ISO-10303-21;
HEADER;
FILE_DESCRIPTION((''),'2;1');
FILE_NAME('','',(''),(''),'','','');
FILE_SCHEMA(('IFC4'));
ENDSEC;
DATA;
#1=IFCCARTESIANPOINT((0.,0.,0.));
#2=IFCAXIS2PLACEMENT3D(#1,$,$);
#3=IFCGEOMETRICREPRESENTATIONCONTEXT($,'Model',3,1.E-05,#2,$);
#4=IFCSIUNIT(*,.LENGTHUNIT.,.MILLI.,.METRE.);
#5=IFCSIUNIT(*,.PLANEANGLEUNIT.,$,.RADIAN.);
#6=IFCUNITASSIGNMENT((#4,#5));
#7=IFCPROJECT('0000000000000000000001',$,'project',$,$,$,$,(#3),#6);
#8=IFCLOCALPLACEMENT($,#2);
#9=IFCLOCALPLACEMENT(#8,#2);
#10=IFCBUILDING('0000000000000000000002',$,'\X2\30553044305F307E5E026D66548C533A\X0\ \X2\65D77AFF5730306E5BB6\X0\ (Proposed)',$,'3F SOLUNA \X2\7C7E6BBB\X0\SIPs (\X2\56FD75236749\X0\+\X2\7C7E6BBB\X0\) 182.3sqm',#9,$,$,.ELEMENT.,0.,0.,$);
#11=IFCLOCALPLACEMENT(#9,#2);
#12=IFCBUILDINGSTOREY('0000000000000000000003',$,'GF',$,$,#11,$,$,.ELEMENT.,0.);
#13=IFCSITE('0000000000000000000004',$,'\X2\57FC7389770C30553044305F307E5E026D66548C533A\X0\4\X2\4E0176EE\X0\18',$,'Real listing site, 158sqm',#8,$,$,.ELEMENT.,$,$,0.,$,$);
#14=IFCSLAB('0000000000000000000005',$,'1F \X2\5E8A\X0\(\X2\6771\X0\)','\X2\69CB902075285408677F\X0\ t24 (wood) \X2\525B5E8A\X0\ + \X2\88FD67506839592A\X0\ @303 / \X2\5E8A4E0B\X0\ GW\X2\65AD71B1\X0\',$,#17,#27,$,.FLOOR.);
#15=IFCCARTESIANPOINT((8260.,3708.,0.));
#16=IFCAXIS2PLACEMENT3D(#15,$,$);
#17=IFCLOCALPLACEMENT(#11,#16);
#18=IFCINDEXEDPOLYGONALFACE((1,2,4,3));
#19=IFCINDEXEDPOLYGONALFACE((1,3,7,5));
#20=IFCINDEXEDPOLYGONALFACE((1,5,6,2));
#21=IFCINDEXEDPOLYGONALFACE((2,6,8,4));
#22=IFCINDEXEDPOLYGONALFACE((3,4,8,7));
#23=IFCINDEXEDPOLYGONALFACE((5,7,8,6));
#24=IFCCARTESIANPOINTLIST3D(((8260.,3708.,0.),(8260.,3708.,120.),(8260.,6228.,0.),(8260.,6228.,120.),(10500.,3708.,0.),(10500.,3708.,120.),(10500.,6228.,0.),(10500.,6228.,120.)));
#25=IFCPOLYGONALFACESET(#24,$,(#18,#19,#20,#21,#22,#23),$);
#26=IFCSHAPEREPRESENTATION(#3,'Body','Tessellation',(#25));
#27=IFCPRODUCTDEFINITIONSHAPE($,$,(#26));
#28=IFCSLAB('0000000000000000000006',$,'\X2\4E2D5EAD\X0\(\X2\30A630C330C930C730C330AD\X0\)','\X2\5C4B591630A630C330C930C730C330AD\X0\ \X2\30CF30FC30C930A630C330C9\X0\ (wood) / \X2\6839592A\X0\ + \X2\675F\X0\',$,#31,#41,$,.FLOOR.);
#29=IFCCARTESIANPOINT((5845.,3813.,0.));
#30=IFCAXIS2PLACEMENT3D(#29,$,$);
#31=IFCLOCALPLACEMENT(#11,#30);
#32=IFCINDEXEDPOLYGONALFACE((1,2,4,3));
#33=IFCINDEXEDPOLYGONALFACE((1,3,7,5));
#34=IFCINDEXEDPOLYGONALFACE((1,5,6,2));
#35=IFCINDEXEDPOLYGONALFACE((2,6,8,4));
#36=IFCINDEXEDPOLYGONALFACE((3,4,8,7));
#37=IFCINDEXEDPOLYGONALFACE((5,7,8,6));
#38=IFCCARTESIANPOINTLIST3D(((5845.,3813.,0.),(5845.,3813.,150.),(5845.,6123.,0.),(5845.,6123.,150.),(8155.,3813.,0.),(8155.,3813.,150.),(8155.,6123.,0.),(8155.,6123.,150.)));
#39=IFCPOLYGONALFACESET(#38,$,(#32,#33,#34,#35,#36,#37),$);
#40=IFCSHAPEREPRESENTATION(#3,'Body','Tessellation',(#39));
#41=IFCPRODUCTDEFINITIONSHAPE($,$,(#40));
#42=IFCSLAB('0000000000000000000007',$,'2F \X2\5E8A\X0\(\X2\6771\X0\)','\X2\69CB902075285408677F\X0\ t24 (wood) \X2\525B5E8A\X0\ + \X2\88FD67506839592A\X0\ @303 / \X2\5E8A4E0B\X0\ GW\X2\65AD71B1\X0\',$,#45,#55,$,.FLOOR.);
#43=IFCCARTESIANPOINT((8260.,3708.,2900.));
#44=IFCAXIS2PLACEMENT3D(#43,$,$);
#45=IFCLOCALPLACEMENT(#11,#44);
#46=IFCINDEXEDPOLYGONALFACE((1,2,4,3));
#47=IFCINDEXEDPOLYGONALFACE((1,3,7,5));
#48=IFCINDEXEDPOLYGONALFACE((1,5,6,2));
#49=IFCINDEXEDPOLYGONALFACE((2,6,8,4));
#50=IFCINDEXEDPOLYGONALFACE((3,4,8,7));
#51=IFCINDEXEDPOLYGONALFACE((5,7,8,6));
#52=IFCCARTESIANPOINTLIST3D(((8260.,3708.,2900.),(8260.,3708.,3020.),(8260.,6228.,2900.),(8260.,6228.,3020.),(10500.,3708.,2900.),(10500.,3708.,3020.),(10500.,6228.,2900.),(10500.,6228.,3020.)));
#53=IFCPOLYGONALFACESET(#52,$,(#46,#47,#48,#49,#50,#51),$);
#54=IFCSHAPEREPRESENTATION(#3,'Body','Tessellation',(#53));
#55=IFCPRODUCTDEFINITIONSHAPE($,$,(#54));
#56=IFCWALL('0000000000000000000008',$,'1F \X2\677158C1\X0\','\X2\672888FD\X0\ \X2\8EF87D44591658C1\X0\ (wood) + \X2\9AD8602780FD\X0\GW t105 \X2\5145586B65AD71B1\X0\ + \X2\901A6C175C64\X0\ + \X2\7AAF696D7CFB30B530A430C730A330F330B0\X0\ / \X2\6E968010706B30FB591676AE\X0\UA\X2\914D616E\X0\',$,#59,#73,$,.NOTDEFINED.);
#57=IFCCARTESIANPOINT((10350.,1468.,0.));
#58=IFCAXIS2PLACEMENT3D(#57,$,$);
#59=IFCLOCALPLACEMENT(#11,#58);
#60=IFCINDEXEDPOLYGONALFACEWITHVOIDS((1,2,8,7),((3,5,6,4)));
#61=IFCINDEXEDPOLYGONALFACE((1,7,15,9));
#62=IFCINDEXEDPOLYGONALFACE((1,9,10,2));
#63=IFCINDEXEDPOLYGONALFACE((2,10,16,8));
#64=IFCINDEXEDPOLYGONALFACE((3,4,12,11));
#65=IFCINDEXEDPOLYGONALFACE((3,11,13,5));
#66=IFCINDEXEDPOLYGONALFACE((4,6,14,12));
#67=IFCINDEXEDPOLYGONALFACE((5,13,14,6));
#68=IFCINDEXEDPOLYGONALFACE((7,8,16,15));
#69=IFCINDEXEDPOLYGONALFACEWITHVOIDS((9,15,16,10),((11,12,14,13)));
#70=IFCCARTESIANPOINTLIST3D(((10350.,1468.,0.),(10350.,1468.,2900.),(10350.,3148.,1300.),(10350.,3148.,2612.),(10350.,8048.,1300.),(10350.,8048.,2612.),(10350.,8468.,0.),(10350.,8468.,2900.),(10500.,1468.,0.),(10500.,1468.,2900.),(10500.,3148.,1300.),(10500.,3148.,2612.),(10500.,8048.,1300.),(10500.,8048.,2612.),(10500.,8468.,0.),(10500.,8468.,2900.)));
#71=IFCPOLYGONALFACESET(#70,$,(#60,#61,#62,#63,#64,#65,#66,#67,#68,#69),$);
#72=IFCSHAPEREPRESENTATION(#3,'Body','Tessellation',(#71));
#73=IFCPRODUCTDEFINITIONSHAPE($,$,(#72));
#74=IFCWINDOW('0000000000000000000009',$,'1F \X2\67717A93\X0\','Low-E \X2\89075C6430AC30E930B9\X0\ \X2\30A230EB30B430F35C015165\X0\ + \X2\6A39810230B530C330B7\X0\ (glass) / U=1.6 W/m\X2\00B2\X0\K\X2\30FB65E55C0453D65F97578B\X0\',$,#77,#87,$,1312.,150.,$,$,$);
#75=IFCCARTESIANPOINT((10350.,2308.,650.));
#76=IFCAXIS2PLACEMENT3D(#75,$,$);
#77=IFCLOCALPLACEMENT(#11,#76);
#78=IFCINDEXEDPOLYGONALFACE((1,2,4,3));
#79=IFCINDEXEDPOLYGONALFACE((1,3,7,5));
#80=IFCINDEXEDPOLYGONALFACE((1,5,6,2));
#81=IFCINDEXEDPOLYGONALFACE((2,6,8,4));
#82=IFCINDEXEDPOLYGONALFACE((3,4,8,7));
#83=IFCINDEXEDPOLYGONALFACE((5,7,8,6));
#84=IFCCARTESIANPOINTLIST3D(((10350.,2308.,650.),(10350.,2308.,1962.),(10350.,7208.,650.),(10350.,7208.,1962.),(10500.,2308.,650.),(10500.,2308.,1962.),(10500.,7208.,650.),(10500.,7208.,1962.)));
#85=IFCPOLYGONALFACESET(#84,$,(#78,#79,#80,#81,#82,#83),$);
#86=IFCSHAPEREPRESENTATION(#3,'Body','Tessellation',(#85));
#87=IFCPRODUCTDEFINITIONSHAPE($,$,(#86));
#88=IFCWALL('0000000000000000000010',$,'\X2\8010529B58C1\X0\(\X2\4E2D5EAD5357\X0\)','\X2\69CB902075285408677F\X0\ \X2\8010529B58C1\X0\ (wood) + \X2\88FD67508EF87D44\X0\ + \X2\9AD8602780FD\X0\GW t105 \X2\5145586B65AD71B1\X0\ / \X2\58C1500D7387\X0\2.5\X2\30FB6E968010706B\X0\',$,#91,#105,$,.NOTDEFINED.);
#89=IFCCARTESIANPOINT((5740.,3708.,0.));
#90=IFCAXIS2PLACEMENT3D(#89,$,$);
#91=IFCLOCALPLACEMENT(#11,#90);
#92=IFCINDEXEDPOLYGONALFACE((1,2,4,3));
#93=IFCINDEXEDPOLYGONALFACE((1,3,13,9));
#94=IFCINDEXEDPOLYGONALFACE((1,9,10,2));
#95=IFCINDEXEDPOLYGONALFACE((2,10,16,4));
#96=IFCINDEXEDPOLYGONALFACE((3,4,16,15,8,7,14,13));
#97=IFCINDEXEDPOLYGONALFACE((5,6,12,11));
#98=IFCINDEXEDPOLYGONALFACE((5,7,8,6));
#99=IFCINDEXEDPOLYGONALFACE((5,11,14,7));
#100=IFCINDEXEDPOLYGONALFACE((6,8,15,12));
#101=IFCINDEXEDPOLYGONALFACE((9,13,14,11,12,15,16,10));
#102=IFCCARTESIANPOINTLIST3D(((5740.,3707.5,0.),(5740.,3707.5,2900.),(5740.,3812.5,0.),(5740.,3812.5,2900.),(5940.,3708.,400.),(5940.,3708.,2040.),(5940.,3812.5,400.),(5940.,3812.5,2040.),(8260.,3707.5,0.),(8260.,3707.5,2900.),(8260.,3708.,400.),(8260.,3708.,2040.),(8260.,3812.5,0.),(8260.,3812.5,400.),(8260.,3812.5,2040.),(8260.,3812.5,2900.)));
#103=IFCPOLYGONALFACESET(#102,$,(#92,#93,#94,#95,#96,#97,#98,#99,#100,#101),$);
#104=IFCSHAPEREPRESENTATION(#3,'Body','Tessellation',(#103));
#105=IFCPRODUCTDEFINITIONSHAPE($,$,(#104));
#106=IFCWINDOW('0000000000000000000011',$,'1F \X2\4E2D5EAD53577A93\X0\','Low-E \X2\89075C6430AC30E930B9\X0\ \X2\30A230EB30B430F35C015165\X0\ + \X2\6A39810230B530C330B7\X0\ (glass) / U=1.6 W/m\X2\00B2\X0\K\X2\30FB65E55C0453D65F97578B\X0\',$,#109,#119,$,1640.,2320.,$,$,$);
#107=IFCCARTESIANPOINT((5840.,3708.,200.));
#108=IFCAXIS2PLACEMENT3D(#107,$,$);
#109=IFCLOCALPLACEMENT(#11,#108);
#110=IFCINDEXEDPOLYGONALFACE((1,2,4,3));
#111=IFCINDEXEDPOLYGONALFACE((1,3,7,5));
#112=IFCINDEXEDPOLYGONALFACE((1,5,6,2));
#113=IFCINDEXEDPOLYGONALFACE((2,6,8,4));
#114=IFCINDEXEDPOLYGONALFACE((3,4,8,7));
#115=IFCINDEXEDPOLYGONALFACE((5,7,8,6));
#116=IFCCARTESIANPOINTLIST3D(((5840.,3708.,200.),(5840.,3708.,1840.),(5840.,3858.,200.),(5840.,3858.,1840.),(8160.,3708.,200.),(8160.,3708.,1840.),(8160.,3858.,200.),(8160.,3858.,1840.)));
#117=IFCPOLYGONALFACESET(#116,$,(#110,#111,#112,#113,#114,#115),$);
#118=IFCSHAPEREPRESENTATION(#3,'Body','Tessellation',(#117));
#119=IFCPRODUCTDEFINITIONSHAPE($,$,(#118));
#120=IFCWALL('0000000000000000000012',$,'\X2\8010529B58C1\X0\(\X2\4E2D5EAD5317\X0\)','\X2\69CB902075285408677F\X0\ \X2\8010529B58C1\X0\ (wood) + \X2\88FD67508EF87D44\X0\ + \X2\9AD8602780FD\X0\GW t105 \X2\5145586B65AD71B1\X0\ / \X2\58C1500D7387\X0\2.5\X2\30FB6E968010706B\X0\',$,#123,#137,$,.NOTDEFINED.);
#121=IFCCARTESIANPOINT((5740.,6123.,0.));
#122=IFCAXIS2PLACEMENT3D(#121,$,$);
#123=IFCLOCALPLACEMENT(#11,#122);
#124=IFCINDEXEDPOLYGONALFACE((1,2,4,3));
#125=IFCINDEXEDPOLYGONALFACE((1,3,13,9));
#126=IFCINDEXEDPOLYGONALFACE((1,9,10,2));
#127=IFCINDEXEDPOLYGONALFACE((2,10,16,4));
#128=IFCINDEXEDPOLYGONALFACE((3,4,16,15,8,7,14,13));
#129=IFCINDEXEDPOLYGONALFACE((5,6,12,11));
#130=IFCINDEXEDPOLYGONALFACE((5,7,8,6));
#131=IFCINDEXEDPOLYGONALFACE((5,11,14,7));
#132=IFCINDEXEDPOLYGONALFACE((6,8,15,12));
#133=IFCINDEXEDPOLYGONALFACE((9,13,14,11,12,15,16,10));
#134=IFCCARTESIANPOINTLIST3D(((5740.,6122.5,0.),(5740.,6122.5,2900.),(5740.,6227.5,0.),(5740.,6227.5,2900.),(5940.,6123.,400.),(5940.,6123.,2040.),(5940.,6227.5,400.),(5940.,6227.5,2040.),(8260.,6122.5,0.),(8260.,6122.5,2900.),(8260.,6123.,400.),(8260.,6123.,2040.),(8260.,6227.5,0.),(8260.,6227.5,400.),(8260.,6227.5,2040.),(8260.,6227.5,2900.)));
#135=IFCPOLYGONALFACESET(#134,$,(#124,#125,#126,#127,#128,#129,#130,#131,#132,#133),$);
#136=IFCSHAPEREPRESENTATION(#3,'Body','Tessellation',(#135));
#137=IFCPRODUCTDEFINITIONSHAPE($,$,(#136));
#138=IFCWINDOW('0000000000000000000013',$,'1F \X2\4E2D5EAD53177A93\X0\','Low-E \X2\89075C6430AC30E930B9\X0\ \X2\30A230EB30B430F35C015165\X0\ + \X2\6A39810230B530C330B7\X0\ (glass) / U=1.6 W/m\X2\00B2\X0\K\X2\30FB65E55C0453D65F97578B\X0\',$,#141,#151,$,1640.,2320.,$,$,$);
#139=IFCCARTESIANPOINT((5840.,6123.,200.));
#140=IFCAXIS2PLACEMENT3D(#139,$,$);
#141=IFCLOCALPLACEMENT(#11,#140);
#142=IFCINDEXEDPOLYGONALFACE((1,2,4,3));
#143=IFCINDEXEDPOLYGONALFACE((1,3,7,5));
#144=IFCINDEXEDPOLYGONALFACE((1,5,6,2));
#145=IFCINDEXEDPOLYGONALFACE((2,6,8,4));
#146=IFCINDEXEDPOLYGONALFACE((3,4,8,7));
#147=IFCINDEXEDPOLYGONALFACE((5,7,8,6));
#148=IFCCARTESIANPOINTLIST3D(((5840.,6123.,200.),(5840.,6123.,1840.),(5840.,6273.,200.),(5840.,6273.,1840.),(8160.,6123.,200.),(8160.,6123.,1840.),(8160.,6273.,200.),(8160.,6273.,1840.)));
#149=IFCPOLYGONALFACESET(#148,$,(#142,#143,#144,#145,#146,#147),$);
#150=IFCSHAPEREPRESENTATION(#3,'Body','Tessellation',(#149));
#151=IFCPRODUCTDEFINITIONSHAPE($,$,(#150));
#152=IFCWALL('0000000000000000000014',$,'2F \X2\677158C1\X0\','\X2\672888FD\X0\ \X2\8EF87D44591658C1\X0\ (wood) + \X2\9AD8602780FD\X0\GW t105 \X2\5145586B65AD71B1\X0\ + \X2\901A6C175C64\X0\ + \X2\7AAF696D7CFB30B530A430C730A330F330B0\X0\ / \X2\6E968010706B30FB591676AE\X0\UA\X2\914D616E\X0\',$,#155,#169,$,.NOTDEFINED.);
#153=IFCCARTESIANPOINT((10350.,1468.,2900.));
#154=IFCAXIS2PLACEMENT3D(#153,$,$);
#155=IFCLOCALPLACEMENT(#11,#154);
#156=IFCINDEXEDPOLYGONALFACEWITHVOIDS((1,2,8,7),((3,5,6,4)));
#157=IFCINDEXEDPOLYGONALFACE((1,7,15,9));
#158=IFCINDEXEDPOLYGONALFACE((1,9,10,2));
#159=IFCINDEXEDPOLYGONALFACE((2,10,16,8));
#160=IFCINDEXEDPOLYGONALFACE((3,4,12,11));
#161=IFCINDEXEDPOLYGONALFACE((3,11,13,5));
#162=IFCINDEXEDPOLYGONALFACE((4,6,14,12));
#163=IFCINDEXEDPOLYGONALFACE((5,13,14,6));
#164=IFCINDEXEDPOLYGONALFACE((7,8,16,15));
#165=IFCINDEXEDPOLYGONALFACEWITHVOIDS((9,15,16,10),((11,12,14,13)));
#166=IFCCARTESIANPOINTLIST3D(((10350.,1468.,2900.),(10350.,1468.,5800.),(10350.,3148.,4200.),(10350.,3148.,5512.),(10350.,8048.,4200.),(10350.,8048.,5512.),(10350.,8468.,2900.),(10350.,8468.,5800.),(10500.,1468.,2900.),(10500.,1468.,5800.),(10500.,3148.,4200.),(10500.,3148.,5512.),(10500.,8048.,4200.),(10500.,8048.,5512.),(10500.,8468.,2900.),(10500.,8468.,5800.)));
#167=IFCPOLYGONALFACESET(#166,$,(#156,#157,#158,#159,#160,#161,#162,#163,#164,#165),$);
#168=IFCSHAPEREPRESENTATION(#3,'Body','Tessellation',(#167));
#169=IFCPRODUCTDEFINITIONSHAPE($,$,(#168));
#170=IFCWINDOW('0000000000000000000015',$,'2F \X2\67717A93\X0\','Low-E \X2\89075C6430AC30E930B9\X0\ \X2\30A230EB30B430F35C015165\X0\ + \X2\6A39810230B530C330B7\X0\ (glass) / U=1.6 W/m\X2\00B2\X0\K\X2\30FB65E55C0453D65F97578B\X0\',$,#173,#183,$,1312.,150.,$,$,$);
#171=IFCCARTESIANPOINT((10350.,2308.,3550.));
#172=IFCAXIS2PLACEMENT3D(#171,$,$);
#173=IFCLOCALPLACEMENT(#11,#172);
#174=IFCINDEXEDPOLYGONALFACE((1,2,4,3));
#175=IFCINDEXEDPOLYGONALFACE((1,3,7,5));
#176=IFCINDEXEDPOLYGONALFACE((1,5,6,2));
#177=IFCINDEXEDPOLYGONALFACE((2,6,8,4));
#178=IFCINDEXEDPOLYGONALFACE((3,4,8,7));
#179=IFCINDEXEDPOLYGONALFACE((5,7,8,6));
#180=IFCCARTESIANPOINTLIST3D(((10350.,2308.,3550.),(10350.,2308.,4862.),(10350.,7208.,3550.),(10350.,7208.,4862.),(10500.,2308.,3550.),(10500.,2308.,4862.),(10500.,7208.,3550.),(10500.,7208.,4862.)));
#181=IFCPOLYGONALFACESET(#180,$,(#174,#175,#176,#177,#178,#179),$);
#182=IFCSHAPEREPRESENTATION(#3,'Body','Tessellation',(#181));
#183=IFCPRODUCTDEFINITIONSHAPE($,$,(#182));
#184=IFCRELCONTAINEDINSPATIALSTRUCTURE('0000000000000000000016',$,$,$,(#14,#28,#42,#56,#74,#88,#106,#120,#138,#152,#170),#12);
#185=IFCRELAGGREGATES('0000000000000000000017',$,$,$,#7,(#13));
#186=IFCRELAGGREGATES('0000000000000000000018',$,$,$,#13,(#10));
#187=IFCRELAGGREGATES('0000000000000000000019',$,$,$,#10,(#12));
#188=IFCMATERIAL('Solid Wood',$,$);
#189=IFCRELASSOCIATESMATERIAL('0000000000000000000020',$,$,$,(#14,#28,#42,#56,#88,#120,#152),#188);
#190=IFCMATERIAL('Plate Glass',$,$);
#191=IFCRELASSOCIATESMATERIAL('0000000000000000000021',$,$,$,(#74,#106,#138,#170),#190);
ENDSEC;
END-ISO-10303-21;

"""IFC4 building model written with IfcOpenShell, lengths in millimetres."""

from ifc_helpers import new_model, si_unit, frame, frame_2d, origin, place, context, project, spatial, rectangle, extrude, material, element, fill, save


model = new_model("IFC4")

# Units and contexts
model_context = context("Model", 3, precision=1e-05, world=origin())
ifc_project = project(units=[si_unit("LENGTHUNIT", "METRE", prefix="MILLI"), si_unit("PLANEANGLEUNIT", "RADIAN")], contexts=[model_context])

# Site, building, storey
site_placement = place(None, origin())
site = spatial("IfcSite", under=ifc_project, at=site_placement, Name="埼玉県さいたま市浦和区4丁目18", ObjectType="Real listing site, 158sqm", CompositionType="ELEMENT", RefElevation=0.0)
building_placement = place(site_placement, origin())
building = spatial("IfcBuilding", under=site, at=building_placement, Name="さいたま市浦和区 旗竿地の家 (Proposed)", ObjectType="3F SOLUNA 籾殻SIPs (国産杉+籾殻) 182.3sqm", CompositionType="ELEMENT", ElevationOfRefHeight=0.0, ElevationOfTerrain=0.0)
storey_placement = place(building_placement, origin())
storey = spatial("IfcBuildingStorey", under=building, at=storey_placement, Name="GF", CompositionType="ELEMENT", Elevation=0.0)

# Slabs
ifc_material_1 = material(Name="Solid Wood")
slab_1_placement = place(storey_placement, frame((8260.0, 3708.0, 0.0)))
element("IfcSlab", 1, at=slab_1_placement, inside=storey, material=ifc_material_1, Name="1F 床(東)", Description="構造用合板 t24 (wood) 剛床 + 製材根太 @303 / 床下 GW断熱", PredefinedType="FLOOR", context=model_context, shape_type="SweptSolid", body=[
    extrude(rectangle(XDim=2240.0, YDim=2520.0, at=frame_2d((1120.0, 1260.0))), frame((8260.0, 3708.0, 0.0)), (0.0, 0.0, 1.0), 120.0),
])
slab_2_placement = place(storey_placement, frame((5845.0, 3813.0, 0.0)))
element("IfcSlab", 2, at=slab_2_placement, inside=storey, material=ifc_material_1, Name="中庭(ウッドデッキ)", Description="屋外ウッドデッキ ハードウッド (wood) / 根太 + 束", PredefinedType="FLOOR", context=model_context, shape_type="SweptSolid", body=[
    extrude(rectangle(XDim=2310.0, YDim=2310.0, at=frame_2d((1155.0, 1155.0))), frame((5845.0, 3813.0, 0.0)), (0.0, 0.0, 1.0), 150.0),
])
slab_3_placement = place(storey_placement, frame((8260.0, 3708.0, 2900.0)))
element("IfcSlab", 3, at=slab_3_placement, inside=storey, material=ifc_material_1, Name="2F 床(東)", Description="構造用合板 t24 (wood) 剛床 + 製材根太 @303 / 床下 GW断熱", PredefinedType="FLOOR", context=model_context, shape_type="SweptSolid", body=[
    extrude(rectangle(XDim=2240.0, YDim=2520.0, at=frame_2d((1120.0, 1260.0))), frame((8260.0, 3708.0, 2900.0)), (0.0, 0.0, 1.0), 120.0),
])

# Walls, openings, windows
wall_1_placement = place(storey_placement, frame((10350.0, 1468.0, 0.0)))
wall_1 = element("IfcWall", 4, at=wall_1_placement, inside=storey, material=ifc_material_1, Name="1F 東壁", Description="木製 軸組外壁 (wood) + 高性能GW t105 充填断熱 + 通気層 + 窯業系サイディング / 準耐火・外皮UA配慮", PredefinedType="NOTDEFINED", context=model_context, shape_type="SweptSolid", body=[
    extrude(rectangle(XDim=150.0, YDim=7000.0, at=frame_2d((75.0, 3500.0))), frame((10350.0, 1468.0, 0.0)), (0.0, 0.0, 1.0), 2900.0),
])
opening_1_placement = place(storey_placement, frame((10350.0, 2308.0, 650.0)))
opening_1 = element("IfcOpeningElement", 5, at=opening_1_placement, cuts=wall_1, PredefinedType="NOTDEFINED", context=model_context, shape_type="SweptSolid", body=[
    extrude(rectangle(XDim=150.0, YDim=4900.0, at=frame_2d((75.0, 2450.0))), frame((10350.0, 2308.0, 650.0)), (0.0, 0.0, 1.0), 1312.0),
])
ifc_material_2 = material(Name="Plate Glass")
window_1_placement = place(storey_placement, frame((10350.0, 2308.0, 650.0)))
window_1 = element("IfcWindow", 6, at=window_1_placement, inside=storey, material=ifc_material_2, Name="1F 東窓", Description="Low-E 複層ガラス アルゴン封入 + 樹脂サッシ (glass) / U=1.6 W/m²K・日射取得型", OverallHeight=1312.0, OverallWidth=150.0, context=model_context, shape_type="SweptSolid", body=[
    extrude(rectangle(XDim=150.0, YDim=4900.0, at=frame_2d((75.0, 2450.0))), frame((10350.0, 2308.0, 650.0)), (0.0, 0.0, 1.0), 1312.0),
])
fill(opening_1, window_1)
wall_2_placement = place(storey_placement, frame((5740.0, 3708.0, 0.0)))
wall_2 = element("IfcWall", 7, at=wall_2_placement, inside=storey, material=ifc_material_1, Name="耐力壁(中庭南)", Description="構造用合板 耐力壁 (wood) + 製材軸組 + 高性能GW t105 充填断熱 / 壁倍率2.5・準耐火", PredefinedType="NOTDEFINED", context=model_context, shape_type="SweptSolid", body=[
    extrude(rectangle(XDim=2520.0, YDim=105.0, at=frame_2d((1260.0, 52.0))), frame((5740.0, 3708.0, 0.0)), (0.0, 0.0, 1.0), 2900.0),
])
opening_2_placement = place(storey_placement, frame((5840.0, 3708.0, 200.0)))
opening_2 = element("IfcOpeningElement", 8, at=opening_2_placement, cuts=wall_2, PredefinedType="NOTDEFINED", context=model_context, shape_type="SweptSolid", body=[
    extrude(rectangle(XDim=2320.0, YDim=150.0, at=frame_2d((1160.0, 75.0))), frame((5840.0, 3708.0, 200.0)), (0.0, 0.0, 1.0), 1640.0),
])
window_2_placement = place(storey_placement, frame((5840.0, 3708.0, 200.0)))
window_2 = element("IfcWindow", 9, at=window_2_placement, inside=storey, material=ifc_material_2, Name="1F 中庭南窓", Description="Low-E 複層ガラス アルゴン封入 + 樹脂サッシ (glass) / U=1.6 W/m²K・日射取得型", OverallHeight=1640.0, OverallWidth=2320.0, context=model_context, shape_type="SweptSolid", body=[
    extrude(rectangle(XDim=2320.0, YDim=150.0, at=frame_2d((1160.0, 75.0))), frame((5840.0, 3708.0, 200.0)), (0.0, 0.0, 1.0), 1640.0),
])
fill(opening_2, window_2)
wall_3_placement = place(storey_placement, frame((5740.0, 6123.0, 0.0)))
wall_3 = element("IfcWall", 10, at=wall_3_placement, inside=storey, material=ifc_material_1, Name="耐力壁(中庭北)", Description="構造用合板 耐力壁 (wood) + 製材軸組 + 高性能GW t105 充填断熱 / 壁倍率2.5・準耐火", PredefinedType="NOTDEFINED", context=model_context, shape_type="SweptSolid", body=[
    extrude(rectangle(XDim=2520.0, YDim=105.0, at=frame_2d((1260.0, 52.0))), frame((5740.0, 6123.0, 0.0)), (0.0, 0.0, 1.0), 2900.0),
])
opening_3_placement = place(storey_placement, frame((5840.0, 6123.0, 200.0)))
opening_3 = element("IfcOpeningElement", 11, at=opening_3_placement, cuts=wall_3, PredefinedType="NOTDEFINED", context=model_context, shape_type="SweptSolid", body=[
    extrude(rectangle(XDim=2320.0, YDim=150.0, at=frame_2d((1160.0, 75.0))), frame((5840.0, 6123.0, 200.0)), (0.0, 0.0, 1.0), 1640.0),
])
window_3_placement = place(storey_placement, frame((5840.0, 6123.0, 200.0)))
window_3 = element("IfcWindow", 12, at=window_3_placement, inside=storey, material=ifc_material_2, Name="1F 中庭北窓", Description="Low-E 複層ガラス アルゴン封入 + 樹脂サッシ (glass) / U=1.6 W/m²K・日射取得型", OverallHeight=1640.0, OverallWidth=2320.0, context=model_context, shape_type="SweptSolid", body=[
    extrude(rectangle(XDim=2320.0, YDim=150.0, at=frame_2d((1160.0, 75.0))), frame((5840.0, 6123.0, 200.0)), (0.0, 0.0, 1.0), 1640.0),
])
fill(opening_3, window_3)

# Wall, opening, window
wall_4_placement = place(storey_placement, frame((10350.0, 1468.0, 2900.0)))
wall_4 = element("IfcWall", 13, at=wall_4_placement, inside=storey, material=ifc_material_1, Name="2F 東壁", Description="木製 軸組外壁 (wood) + 高性能GW t105 充填断熱 + 通気層 + 窯業系サイディング / 準耐火・外皮UA配慮", PredefinedType="NOTDEFINED", context=model_context, shape_type="SweptSolid", body=[
    extrude(rectangle(XDim=150.0, YDim=7000.0, at=frame_2d((75.0, 3500.0))), frame((10350.0, 1468.0, 2900.0)), (0.0, 0.0, 1.0), 2900.0),
])
opening_4_placement = place(storey_placement, frame((10350.0, 2308.0, 3550.0)))
opening_4 = element("IfcOpeningElement", 14, at=opening_4_placement, cuts=wall_4, PredefinedType="NOTDEFINED", context=model_context, shape_type="SweptSolid", body=[
    extrude(rectangle(XDim=150.0, YDim=4900.0, at=frame_2d((75.0, 2450.0))), frame((10350.0, 2308.0, 3550.0)), (0.0, 0.0, 1.0), 1312.0),
])
window_4_placement = place(storey_placement, frame((10350.0, 2308.0, 3550.0)))
window_4 = element("IfcWindow", 15, at=window_4_placement, inside=storey, material=ifc_material_2, Name="2F 東窓", Description="Low-E 複層ガラス アルゴン封入 + 樹脂サッシ (glass) / U=1.6 W/m²K・日射取得型", OverallHeight=1312.0, OverallWidth=150.0, context=model_context, shape_type="SweptSolid", body=[
    extrude(rectangle(XDim=150.0, YDim=4900.0, at=frame_2d((75.0, 2450.0))), frame((10350.0, 2308.0, 3550.0)), (0.0, 0.0, 1.0), 1312.0),
])
fill(opening_4, window_4)

save(model, "model.ifc")
